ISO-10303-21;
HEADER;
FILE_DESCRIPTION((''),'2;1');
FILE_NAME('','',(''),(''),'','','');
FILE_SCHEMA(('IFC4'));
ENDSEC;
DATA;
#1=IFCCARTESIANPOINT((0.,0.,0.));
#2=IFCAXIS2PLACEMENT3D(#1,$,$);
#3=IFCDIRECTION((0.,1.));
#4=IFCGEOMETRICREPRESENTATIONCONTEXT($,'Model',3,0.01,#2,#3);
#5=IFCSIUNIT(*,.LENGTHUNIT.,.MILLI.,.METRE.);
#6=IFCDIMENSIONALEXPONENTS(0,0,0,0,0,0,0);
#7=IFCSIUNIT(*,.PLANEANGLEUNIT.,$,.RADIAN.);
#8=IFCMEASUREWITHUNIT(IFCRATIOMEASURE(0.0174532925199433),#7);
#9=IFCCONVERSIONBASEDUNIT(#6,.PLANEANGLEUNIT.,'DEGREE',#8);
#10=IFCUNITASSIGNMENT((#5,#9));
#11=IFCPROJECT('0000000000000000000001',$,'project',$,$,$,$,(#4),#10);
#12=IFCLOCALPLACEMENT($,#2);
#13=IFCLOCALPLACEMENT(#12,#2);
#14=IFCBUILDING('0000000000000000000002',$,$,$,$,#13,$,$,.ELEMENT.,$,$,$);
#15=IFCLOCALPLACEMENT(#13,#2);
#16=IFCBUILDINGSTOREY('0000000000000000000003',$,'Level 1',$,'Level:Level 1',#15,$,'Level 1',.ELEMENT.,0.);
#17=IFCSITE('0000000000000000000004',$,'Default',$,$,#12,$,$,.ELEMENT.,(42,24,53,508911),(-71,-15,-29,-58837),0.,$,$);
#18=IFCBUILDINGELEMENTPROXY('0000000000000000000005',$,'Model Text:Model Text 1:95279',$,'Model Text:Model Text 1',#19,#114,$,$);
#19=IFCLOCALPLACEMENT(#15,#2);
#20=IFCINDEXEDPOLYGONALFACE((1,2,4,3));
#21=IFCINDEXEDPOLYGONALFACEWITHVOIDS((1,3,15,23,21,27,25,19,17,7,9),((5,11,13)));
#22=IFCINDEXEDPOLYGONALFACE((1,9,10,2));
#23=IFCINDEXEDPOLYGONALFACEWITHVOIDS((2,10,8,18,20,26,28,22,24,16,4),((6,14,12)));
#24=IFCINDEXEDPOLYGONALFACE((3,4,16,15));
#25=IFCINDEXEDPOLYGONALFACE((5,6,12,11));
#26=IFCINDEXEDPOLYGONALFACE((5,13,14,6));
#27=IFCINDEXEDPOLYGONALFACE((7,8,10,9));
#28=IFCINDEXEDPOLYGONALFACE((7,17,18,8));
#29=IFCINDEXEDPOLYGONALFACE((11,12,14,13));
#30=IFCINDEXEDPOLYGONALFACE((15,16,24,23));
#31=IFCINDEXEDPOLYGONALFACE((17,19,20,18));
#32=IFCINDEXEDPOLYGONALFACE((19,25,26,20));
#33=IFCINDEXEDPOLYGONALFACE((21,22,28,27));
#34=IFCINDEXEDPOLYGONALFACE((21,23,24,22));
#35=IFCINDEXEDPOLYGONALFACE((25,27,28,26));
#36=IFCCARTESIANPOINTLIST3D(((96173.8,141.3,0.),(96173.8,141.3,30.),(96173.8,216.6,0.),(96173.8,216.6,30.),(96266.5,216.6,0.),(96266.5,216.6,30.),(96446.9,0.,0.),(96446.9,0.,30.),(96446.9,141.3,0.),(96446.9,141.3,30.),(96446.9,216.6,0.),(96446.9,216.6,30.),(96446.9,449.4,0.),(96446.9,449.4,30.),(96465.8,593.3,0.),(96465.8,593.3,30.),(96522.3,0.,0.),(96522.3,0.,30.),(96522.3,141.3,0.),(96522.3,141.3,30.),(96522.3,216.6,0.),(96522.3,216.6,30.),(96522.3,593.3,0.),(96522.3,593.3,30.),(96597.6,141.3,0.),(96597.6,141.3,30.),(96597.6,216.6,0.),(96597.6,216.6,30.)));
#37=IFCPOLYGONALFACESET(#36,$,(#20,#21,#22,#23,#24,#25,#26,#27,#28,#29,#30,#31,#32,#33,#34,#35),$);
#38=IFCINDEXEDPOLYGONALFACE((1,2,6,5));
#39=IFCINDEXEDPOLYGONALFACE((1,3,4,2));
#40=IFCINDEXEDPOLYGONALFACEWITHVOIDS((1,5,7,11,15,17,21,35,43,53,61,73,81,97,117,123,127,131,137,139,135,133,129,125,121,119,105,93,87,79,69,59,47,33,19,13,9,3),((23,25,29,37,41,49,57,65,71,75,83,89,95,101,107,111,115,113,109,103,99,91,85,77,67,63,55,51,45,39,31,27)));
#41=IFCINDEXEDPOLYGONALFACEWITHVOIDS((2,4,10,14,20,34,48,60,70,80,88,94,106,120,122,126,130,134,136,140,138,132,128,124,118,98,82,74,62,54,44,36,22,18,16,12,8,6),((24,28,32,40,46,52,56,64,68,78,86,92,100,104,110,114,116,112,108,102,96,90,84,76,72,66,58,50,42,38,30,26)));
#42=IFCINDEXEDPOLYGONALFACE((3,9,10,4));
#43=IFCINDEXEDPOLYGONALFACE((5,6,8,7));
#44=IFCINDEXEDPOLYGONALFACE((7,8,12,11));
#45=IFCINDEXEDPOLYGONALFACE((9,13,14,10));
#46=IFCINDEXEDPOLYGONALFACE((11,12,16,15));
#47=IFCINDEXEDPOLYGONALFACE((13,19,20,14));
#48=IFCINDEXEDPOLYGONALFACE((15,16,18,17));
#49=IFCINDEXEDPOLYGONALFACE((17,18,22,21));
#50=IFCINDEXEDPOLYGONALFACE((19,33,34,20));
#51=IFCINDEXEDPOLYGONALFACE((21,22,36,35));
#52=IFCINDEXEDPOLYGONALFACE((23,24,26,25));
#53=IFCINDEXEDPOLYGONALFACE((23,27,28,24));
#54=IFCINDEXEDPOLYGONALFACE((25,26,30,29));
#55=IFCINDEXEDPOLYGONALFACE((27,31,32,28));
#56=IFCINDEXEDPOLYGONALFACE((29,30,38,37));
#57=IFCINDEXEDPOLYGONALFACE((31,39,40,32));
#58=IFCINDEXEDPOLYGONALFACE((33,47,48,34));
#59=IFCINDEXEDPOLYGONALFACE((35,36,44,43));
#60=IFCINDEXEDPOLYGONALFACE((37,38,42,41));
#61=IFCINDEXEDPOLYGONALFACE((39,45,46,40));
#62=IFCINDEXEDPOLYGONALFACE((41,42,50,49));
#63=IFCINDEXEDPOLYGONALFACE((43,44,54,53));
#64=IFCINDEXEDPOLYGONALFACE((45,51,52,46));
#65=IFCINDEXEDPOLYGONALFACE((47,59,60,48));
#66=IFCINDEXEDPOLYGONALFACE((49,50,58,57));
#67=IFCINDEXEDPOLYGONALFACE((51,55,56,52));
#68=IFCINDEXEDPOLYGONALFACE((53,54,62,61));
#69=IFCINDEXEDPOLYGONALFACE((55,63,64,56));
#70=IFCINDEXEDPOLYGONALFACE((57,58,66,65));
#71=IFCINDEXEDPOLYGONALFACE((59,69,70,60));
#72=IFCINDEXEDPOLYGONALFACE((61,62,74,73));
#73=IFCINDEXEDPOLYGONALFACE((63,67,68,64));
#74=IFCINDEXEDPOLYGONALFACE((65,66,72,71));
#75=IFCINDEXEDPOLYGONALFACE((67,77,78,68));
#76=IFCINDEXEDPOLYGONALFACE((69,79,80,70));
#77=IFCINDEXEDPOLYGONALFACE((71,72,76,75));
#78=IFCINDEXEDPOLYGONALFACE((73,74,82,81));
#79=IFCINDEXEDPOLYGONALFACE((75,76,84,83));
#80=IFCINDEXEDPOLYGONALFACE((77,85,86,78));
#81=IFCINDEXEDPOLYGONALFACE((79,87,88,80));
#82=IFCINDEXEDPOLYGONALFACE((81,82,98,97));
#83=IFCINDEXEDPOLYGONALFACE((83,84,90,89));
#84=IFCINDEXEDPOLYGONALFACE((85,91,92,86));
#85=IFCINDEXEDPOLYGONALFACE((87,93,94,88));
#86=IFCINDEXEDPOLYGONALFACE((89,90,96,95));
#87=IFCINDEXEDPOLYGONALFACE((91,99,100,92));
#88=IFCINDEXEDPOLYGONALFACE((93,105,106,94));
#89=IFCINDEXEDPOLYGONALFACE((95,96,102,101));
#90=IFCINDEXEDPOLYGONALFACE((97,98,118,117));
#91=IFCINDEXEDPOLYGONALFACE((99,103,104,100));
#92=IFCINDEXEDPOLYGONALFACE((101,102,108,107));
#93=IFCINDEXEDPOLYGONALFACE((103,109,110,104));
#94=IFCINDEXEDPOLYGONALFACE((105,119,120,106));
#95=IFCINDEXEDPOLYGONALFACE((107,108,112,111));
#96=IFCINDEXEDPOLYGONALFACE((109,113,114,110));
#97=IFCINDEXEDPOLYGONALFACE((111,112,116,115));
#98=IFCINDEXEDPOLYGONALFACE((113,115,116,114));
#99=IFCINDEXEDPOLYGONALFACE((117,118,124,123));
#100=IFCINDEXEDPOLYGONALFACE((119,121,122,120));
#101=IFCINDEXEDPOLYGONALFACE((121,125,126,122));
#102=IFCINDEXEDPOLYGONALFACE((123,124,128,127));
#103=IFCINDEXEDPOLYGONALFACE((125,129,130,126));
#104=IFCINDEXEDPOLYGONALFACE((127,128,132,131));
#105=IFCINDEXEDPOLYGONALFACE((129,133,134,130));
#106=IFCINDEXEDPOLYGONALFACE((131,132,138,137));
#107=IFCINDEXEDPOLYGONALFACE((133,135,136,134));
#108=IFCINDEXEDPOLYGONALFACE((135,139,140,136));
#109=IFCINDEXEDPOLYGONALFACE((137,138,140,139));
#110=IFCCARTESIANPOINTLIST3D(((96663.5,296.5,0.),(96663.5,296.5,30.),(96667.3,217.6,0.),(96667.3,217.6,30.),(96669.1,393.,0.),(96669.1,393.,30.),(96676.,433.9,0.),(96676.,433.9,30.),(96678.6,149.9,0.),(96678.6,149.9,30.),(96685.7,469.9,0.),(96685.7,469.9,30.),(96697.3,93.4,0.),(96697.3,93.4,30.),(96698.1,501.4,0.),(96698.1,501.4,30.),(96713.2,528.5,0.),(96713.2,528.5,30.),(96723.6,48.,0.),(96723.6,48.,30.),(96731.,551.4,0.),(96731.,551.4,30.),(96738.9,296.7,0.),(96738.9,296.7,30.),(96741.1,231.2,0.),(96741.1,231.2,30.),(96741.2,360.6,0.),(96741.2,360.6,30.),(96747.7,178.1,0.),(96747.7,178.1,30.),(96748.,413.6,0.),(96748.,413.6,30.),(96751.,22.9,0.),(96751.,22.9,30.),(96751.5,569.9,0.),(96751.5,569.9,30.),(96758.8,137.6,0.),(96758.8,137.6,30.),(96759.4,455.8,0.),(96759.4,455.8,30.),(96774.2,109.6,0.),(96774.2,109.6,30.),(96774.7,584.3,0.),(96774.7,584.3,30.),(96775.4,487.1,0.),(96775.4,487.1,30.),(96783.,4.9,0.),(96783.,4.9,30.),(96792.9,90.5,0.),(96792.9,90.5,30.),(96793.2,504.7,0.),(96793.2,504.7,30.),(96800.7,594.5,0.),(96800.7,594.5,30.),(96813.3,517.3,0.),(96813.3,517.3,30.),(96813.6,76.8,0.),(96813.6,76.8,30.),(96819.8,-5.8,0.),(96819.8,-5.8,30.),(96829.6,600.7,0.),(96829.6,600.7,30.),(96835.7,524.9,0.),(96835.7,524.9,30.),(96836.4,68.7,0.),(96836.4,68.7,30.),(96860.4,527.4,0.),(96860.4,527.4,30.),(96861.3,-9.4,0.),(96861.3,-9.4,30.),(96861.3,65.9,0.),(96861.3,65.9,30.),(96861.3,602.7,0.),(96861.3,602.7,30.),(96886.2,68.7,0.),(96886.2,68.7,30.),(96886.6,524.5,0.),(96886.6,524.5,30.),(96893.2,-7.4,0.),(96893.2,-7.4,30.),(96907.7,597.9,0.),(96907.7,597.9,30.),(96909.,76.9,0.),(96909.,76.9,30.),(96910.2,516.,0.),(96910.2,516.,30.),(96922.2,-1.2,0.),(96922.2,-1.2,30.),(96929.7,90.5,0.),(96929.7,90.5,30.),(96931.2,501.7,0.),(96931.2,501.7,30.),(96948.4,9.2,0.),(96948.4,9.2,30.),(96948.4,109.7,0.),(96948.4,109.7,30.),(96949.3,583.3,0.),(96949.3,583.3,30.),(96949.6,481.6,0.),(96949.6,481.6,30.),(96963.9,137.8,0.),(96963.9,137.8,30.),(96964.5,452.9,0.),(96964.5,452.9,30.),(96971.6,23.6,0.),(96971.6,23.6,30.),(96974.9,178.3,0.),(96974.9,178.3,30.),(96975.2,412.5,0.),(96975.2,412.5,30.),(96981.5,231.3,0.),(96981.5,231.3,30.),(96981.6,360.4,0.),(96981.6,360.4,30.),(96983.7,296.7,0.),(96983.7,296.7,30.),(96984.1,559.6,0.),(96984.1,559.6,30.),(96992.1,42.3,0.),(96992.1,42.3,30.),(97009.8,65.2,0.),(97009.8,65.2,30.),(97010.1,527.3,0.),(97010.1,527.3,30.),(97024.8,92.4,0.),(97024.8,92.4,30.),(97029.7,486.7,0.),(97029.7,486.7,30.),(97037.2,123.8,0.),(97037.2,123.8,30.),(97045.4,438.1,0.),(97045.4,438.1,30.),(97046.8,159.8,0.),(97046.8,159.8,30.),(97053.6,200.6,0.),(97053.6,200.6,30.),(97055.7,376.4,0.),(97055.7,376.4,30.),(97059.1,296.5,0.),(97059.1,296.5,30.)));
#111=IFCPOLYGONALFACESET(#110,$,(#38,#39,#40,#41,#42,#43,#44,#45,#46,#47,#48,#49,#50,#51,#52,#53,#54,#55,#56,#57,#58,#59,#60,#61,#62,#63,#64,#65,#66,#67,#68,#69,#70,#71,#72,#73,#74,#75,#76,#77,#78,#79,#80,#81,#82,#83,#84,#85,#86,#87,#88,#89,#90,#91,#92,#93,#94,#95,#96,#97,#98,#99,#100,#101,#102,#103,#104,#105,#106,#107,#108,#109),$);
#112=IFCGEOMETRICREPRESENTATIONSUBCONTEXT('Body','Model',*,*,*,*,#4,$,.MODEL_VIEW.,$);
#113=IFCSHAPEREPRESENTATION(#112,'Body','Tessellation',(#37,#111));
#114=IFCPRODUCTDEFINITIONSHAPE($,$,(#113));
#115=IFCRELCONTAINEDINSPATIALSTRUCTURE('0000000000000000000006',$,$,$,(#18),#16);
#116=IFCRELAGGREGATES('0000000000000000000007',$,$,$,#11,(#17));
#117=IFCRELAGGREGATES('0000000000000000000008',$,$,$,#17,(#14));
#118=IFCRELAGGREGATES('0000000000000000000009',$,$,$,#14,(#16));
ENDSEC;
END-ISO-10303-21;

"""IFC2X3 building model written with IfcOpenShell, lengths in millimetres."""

from ifc_helpers import new_model, entity, si_unit, converted_unit, direction, frame, origin, place, context, subcontext, project, spatial, polyline, outline, extrude, element, save


model = new_model("IFC2X3")

# Units and contexts
model_context = context("Model", 3, precision=0.01, world=origin(), true_north=direction((0.0, 1.0)))
body_context = subcontext(model_context, "Body", "Model", "MODEL_VIEW")
ifc_project = project(units=[si_unit("LENGTHUNIT", "METRE", prefix="MILLI"), converted_unit("PLANEANGLEUNIT", "DEGREE", entity("IfcRatioMeasure", 0.0174532925199433), si_unit("PLANEANGLEUNIT", "RADIAN"), dimensions=[0, 0, 0, 0, 0, 0, 0])], contexts=[model_context])

# Site, building, storey
site_placement = place(None, origin())
site = spatial("IfcSite", under=ifc_project, at=site_placement, Name="Default", CompositionType="ELEMENT", RefLatitude=(42, 24, 53, 508911), RefLongitude=(-71, -15, -29, -58837), RefElevation=0.0)
building_placement = place(site_placement, origin())
building = spatial("IfcBuilding", under=site, at=building_placement, CompositionType="ELEMENT")
storey_placement = place(building_placement, origin())
storey = spatial("IfcBuildingStorey", under=building, at=storey_placement, Name="Level 1", ObjectType="Level:Level 1", LongName="Level 1", CompositionType="ELEMENT", Elevation=0.0)

# Building element proxy
proxy_1_placement = place(storey_placement, origin())
element("IfcBuildingElementProxy", 1, at=proxy_1_placement, inside=storey, Name="Model Text:Model Text 1:95279", ObjectType="Model Text:Model Text 1", context=body_context, shape_type="SweptSolid", body=[
    extrude(outline(polyline([(-6.8, -218.3), (68.5, -218.3), (68.5, -77.1), (143.8, -77.1), (143.8, -1.7), (68.5, -1.7), (68.5, 375.0), (12.0, 375.0), (-280.0, -1.7), (-280.0, -77.1), (-6.8, -77.1), (-6.8, -218.3)]), holes=[polyline([(-6.8, -1.7), (-187.3, -1.7), (-6.8, 231.1), (-6.8, -1.7)])]), frame((96453.8, 218.3, 0.0)), (0.0, 0.0, 1.0), 30.0),
    extrude(outline(polyline([(-10.6, -198.7), (68.3, -198.7), (136.5, -190.7), (193.9, -174.7), (240.5, -150.6), (266.9, -124.4), (286.3, -93.2), (298.8, -57.0), (304.3, -15.7), (303.8, 16.2), (299.0, 45.5), (289.9, 72.1), (276.6, 96.0), (258.9, 117.3), (236.9, 136.2), (210.4, 152.5), (179.6, 166.3), (144.1, 177.6), (103.7, 186.3), (8.2, 196.4), (-71.8, 196.7), (-134.0, 189.4), (-183.3, 176.1), (-224.7, 158.4), (-258.2, 133.9), (-283.5, 100.3), (-300.1, 59.5), (-307.1, 13.4), (-306.6, -18.4), (-301.8, -47.5), (-292.8, -74.0), (-279.6, -97.9), (-262.0, -119.2), (-240.0, -138.1), (-213.6, -154.5), (-182.8, -168.4), (-147.3, -179.8), (-106.7, -188.6), (-10.6, -198.7)]), holes=[polyline([(-7.2, -123.5), (-71.0, -118.2), (-123.6, -108.8), (-165.2, -95.4), (-195.7, -78.0), (-212.4, -59.4), (-224.1, -38.7), (-230.6, -15.9), (-231.9, 8.9), (-227.8, 35.0), (-218.1, 58.1), (-202.8, 78.4), (-182.0, 95.8), (-152.6, 109.4), (-111.7, 118.1), (-59.4, 122.0), (4.4, 121.1), (69.6, 115.8), (122.2, 106.7), (162.2, 93.7), (189.5, 77.0), (207.7, 57.4), (220.4, 36.0), (227.5, 12.8), (229.1, -12.1), (225.2, -36.8), (215.9, -59.2), (201.3, -79.3), (181.4, -97.1), (152.6, -111.2), (111.6, -120.3), (58.3, -124.4), (-7.2, -123.5)])]), frame((96862.6, 295.3, 0.0), z_axis=(0.0, 0.0, 1.0), x_axis=(0.047515, -0.998871, 0.0)), (0.0, 0.0, 1.0), 30.0),
])

save(model, "model.ifc")
